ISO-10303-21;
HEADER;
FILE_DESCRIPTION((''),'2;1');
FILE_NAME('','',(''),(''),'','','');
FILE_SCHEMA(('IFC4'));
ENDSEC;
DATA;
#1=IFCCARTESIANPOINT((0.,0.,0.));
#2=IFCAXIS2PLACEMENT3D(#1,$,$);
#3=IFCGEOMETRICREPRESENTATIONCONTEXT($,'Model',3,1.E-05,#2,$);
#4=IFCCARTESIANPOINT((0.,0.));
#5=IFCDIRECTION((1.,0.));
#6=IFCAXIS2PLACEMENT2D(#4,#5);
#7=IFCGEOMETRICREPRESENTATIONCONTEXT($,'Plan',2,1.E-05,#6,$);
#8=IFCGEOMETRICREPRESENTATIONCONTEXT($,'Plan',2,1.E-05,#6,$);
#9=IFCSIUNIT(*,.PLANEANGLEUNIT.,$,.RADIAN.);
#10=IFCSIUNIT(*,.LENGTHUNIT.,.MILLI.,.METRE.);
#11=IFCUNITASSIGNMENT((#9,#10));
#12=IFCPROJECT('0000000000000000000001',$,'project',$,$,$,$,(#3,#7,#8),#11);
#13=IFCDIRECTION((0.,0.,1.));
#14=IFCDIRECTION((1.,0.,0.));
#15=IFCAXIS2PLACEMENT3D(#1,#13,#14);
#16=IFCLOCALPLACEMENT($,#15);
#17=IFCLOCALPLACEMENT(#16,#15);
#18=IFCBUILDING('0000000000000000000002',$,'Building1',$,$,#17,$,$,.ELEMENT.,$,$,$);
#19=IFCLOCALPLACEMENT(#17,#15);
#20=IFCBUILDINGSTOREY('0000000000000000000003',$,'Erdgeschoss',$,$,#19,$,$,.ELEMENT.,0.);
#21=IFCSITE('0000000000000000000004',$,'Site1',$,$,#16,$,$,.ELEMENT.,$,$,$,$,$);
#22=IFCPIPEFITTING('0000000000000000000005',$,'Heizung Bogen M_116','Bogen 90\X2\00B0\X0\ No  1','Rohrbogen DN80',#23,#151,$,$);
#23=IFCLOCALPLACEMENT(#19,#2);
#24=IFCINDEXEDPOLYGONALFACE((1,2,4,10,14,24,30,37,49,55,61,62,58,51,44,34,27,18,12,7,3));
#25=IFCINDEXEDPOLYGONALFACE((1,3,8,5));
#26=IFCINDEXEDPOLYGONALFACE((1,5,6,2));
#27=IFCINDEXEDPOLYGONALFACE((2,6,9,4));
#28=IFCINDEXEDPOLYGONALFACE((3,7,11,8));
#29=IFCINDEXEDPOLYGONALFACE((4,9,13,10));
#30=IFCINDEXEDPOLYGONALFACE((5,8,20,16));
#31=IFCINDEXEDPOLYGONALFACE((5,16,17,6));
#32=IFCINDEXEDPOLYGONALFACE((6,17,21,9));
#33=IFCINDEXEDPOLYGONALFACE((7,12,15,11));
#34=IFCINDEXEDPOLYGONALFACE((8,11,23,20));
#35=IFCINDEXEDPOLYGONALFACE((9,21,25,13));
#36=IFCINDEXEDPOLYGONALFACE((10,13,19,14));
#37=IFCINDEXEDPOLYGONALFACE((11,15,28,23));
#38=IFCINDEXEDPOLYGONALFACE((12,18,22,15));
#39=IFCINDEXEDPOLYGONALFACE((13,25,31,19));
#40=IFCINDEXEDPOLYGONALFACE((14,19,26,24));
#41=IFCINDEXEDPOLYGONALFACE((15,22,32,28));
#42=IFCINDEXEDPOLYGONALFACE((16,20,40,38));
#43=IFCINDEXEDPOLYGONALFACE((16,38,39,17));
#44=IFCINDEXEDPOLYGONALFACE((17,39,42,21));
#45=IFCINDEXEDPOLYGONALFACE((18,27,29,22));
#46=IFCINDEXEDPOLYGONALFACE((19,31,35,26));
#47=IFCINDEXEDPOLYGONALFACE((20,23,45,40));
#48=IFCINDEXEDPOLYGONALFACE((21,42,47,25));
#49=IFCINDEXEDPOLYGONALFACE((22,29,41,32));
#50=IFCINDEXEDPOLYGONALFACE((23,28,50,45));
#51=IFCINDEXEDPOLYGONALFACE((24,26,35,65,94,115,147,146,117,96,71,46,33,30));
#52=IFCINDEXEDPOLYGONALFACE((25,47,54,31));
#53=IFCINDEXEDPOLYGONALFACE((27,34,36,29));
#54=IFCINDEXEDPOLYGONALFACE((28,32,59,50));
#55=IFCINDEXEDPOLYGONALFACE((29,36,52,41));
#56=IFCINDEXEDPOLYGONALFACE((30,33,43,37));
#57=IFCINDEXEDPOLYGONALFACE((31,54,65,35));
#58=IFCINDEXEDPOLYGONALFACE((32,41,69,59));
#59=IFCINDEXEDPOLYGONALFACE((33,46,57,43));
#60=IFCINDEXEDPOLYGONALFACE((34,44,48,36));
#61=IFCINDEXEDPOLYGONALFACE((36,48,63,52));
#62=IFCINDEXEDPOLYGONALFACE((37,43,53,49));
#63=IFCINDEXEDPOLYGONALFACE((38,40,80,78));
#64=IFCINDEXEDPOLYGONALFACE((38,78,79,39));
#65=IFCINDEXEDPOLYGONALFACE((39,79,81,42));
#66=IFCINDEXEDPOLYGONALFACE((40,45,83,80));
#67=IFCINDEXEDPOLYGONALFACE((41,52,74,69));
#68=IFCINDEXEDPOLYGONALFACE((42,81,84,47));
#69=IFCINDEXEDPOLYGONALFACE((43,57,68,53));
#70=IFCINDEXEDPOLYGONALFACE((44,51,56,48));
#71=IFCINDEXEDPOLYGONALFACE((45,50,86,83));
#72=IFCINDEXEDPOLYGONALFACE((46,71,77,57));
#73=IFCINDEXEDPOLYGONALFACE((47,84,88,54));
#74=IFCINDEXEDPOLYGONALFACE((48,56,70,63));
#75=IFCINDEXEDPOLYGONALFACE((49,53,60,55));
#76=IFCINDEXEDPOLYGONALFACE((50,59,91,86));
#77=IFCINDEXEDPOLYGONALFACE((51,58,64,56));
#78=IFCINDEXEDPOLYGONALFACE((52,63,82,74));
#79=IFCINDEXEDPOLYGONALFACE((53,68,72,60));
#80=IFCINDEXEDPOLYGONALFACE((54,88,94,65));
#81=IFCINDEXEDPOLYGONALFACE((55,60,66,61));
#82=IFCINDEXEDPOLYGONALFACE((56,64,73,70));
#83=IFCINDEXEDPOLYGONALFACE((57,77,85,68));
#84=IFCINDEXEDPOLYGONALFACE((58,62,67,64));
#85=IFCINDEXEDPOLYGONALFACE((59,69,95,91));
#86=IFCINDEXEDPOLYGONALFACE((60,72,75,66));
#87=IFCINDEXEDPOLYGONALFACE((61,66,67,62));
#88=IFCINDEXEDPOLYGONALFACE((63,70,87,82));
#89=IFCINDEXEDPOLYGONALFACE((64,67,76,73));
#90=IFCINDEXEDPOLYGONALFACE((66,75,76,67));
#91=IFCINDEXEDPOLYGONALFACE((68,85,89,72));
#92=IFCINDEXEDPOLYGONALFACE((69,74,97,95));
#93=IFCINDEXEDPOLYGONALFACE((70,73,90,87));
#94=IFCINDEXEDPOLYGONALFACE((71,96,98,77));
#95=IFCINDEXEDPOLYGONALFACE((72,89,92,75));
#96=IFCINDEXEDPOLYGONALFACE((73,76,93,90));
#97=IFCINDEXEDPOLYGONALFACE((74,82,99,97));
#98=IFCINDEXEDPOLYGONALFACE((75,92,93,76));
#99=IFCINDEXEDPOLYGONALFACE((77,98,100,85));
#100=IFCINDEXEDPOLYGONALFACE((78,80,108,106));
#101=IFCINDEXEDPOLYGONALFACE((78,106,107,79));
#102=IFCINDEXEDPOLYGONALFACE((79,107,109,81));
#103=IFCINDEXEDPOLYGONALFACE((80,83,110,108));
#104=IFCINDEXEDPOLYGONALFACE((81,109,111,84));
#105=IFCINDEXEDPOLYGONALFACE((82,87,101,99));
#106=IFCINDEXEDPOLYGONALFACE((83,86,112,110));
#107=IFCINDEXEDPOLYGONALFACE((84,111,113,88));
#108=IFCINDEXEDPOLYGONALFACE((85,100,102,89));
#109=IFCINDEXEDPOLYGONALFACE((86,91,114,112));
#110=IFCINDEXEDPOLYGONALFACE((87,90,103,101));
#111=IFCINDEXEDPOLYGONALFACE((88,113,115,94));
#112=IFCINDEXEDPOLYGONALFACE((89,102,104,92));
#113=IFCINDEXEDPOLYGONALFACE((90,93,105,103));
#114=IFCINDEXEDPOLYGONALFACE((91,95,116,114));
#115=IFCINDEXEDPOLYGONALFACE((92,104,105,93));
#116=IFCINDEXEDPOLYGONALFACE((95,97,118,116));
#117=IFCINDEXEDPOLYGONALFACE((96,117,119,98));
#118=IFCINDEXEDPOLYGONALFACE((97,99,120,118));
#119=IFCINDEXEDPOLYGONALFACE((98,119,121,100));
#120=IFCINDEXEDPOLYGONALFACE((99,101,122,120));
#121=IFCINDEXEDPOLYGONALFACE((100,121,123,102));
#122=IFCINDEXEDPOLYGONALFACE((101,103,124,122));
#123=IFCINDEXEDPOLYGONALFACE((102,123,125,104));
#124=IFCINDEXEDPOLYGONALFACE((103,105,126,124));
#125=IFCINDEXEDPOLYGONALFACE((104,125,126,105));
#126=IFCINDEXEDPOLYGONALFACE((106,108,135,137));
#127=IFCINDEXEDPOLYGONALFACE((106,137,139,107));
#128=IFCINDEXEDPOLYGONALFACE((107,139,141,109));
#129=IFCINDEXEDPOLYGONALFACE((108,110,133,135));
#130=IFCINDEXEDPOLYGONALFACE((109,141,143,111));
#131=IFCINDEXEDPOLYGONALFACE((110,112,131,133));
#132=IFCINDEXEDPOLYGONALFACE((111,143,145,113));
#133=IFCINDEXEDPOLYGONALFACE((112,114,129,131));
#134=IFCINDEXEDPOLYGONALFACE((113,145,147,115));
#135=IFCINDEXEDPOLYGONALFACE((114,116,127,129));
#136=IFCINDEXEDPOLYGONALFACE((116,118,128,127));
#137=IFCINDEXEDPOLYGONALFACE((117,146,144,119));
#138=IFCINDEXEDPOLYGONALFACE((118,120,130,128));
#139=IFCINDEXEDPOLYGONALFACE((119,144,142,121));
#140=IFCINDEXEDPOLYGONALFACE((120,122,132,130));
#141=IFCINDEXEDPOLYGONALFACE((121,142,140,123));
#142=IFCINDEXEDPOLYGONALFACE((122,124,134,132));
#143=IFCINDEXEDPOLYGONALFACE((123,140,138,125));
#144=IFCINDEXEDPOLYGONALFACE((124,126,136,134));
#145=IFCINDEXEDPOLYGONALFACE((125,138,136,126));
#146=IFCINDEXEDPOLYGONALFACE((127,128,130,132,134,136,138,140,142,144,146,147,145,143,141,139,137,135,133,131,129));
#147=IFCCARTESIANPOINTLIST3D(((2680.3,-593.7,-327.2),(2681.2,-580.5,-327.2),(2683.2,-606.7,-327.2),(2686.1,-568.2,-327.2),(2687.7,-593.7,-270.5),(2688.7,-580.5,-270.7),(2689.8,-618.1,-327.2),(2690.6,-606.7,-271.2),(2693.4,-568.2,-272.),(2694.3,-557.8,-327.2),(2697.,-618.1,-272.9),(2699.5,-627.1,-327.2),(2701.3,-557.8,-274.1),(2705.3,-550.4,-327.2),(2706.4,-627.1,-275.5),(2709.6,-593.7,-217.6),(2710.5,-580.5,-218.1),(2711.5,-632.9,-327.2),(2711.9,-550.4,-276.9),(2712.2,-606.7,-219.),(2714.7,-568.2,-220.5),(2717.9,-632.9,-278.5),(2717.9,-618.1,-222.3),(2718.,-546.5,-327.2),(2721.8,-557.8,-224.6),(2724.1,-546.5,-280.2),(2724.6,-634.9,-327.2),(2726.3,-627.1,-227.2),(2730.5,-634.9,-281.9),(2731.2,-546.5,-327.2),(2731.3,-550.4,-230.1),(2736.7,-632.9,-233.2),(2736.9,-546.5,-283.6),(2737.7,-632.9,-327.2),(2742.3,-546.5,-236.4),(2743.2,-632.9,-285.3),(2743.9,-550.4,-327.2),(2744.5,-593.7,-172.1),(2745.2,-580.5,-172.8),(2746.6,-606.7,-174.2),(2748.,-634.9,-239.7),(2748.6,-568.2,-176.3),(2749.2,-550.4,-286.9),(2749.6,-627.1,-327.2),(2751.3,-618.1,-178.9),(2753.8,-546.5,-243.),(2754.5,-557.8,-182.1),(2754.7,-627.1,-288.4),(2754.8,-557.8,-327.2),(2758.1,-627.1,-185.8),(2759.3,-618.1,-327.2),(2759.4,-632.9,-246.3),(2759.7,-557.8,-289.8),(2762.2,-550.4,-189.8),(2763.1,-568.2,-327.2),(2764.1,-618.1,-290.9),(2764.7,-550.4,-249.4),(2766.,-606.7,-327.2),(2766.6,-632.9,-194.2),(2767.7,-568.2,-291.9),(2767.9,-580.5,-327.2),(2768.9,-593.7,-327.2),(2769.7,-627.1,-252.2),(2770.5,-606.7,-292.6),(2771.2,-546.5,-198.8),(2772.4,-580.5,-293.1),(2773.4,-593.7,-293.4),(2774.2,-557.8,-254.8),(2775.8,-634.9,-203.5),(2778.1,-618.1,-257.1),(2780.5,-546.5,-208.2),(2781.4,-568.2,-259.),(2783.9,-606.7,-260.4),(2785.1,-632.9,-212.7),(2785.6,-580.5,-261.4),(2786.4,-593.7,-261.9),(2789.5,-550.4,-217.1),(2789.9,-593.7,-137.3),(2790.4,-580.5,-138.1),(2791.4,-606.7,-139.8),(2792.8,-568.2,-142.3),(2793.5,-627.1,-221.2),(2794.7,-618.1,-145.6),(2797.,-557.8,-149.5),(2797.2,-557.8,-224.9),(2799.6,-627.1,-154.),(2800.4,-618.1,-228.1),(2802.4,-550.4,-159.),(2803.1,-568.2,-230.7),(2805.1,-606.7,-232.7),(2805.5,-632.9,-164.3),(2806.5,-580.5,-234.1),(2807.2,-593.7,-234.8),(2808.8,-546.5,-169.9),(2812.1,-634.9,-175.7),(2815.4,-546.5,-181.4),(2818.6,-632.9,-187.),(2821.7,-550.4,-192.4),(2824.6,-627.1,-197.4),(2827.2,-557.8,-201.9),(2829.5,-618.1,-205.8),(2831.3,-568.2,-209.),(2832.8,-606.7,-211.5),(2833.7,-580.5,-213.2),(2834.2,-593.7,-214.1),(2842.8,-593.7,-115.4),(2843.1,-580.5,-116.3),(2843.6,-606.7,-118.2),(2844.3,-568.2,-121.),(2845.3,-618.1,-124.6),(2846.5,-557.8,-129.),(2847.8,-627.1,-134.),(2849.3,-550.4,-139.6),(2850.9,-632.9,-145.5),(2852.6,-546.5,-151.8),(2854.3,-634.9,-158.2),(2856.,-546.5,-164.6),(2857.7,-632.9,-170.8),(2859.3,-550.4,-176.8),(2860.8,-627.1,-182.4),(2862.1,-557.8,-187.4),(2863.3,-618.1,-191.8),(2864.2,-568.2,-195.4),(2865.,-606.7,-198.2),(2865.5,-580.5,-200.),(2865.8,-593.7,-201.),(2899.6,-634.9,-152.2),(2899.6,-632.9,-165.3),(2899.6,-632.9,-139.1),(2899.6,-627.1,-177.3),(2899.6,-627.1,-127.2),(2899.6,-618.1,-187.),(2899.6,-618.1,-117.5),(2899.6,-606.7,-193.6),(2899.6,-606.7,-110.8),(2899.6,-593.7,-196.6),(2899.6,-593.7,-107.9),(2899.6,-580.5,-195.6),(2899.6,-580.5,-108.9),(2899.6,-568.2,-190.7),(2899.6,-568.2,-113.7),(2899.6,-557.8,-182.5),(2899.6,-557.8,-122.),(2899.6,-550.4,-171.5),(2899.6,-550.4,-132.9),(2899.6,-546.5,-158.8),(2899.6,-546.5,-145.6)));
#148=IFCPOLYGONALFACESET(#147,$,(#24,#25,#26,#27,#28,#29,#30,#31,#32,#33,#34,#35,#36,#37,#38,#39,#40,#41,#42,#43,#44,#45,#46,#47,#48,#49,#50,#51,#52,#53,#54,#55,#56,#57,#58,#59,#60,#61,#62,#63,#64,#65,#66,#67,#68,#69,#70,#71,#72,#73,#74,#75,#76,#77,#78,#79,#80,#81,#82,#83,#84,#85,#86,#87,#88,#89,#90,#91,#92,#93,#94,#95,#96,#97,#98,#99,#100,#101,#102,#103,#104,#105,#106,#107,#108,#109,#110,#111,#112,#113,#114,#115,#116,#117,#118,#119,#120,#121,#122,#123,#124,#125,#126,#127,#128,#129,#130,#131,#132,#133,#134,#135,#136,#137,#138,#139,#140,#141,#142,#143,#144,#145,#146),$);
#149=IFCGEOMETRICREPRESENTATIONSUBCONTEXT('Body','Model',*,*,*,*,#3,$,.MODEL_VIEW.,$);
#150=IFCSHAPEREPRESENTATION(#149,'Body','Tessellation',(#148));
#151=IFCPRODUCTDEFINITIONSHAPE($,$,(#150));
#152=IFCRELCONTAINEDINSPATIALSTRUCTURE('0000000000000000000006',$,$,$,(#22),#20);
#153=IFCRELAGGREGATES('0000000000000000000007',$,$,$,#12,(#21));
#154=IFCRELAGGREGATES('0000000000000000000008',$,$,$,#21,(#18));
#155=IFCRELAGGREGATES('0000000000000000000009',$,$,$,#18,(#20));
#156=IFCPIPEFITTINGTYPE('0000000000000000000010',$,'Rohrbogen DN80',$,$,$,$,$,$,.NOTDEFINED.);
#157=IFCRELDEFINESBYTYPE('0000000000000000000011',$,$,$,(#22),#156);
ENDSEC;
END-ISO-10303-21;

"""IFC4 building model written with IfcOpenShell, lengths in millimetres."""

from ifc_helpers import new_model, entity, si_unit, frame, origin, origin_with_axes, origin_2d_with_axis, place, context, subcontext, project, spatial, shape, source, transform, mapped, type_object, element, save


model = new_model("IFC4")

# Units and contexts
model_context = context("Model", 3, precision=1e-05, world=origin())
plan_context_1 = context("Plan", 2, precision=1e-05, world=origin_2d_with_axis())
plan_context_2 = context("Plan", 2, precision=1e-05, world=origin_2d_with_axis())
body_context = subcontext(model_context, "Body", "Model", "MODEL_VIEW")
ifc_project = project(units=[si_unit("PLANEANGLEUNIT", "RADIAN"), si_unit("LENGTHUNIT", "METRE", prefix="MILLI")], contexts=[model_context, plan_context_1, plan_context_2])

# Site, building, storey
site_placement = place(None, origin_with_axes())
site = spatial("IfcSite", under=ifc_project, at=site_placement, Name="Site1", CompositionType="ELEMENT")
building_placement = place(site_placement, origin_with_axes())
building = spatial("IfcBuilding", under=site, at=building_placement, Name="Building1", CompositionType="ELEMENT")
storey_placement = place(building_placement, origin_with_axes())
storey = spatial("IfcBuildingStorey", under=building, at=storey_placement, Name="Erdgeschoss", CompositionType="ELEMENT", Elevation=0.0)

# Shared definitions
pipe_fitting_type_1 = type_object("IfcPipeFittingType", Name="Rohrbogen DN80", PredefinedType="NOTDEFINED")

# Pipe fitting
shared_shape_1 = source(origin_with_axes(), body_context, "Body", "SolidModel", [
    entity("IfcRevolvedAreaSolid", entity("IfcCircleProfileDef", "AREA", None, entity("IfcAxis2Placement2D", entity("IfcCartesianPoint", [0.0, 0.0]), entity("IfcDirection", [1.0, 0.0])), 44.5), entity("IfcAxis2Placement3D", entity("IfcCartesianPoint", [109.7, -65.3, 0.0]), entity("IfcDirection", [-1.0, 0.0, 0.0]), entity("IfcDirection", [0.0, 0.0, 1.0])), entity("IfcAxis1Placement", entity("IfcCartesianPoint", [0.0, 175.0, 0.0]), entity("IfcDirection", [-1.0, 0.0, 0.0])), 1.570796),
])
pipe_fitting_1_placement = place(storey_placement, frame((2789.9, -590.4, -217.5), z_axis=(0.0, 0.0, 1.0), x_axis=(1.0, 0.0, 0.0)))
element("IfcPipeFitting", 1, at=pipe_fitting_1_placement, inside=storey, type_object=pipe_fitting_type_1, Name="Heizung Bogen M_116", Description="Bogen 90° No  1", ObjectType="Rohrbogen DN80", shapes=[
    shape(body_context, "Body", "MappedRepresentation", [mapped(shared_shape_1, transform((0.0, 0.0, 0.0), x_axis=(0.0, 0.0, -1.0), y_axis=(1.0, 0.0, 0.0), z_axis=(0.0, -1.0, 0.0), scale=1.0))]),
    shape(body_context, "Body", "MappedRepresentation", [mapped(shared_shape_1, transform((0.0, 0.0, 0.0), x_axis=(0.0, 0.0, -1.0), y_axis=(1.0, 0.0, 0.0), z_axis=(0.0, -1.0, 0.0), scale=1.0))]),
])

save(model, "model.ifc")
